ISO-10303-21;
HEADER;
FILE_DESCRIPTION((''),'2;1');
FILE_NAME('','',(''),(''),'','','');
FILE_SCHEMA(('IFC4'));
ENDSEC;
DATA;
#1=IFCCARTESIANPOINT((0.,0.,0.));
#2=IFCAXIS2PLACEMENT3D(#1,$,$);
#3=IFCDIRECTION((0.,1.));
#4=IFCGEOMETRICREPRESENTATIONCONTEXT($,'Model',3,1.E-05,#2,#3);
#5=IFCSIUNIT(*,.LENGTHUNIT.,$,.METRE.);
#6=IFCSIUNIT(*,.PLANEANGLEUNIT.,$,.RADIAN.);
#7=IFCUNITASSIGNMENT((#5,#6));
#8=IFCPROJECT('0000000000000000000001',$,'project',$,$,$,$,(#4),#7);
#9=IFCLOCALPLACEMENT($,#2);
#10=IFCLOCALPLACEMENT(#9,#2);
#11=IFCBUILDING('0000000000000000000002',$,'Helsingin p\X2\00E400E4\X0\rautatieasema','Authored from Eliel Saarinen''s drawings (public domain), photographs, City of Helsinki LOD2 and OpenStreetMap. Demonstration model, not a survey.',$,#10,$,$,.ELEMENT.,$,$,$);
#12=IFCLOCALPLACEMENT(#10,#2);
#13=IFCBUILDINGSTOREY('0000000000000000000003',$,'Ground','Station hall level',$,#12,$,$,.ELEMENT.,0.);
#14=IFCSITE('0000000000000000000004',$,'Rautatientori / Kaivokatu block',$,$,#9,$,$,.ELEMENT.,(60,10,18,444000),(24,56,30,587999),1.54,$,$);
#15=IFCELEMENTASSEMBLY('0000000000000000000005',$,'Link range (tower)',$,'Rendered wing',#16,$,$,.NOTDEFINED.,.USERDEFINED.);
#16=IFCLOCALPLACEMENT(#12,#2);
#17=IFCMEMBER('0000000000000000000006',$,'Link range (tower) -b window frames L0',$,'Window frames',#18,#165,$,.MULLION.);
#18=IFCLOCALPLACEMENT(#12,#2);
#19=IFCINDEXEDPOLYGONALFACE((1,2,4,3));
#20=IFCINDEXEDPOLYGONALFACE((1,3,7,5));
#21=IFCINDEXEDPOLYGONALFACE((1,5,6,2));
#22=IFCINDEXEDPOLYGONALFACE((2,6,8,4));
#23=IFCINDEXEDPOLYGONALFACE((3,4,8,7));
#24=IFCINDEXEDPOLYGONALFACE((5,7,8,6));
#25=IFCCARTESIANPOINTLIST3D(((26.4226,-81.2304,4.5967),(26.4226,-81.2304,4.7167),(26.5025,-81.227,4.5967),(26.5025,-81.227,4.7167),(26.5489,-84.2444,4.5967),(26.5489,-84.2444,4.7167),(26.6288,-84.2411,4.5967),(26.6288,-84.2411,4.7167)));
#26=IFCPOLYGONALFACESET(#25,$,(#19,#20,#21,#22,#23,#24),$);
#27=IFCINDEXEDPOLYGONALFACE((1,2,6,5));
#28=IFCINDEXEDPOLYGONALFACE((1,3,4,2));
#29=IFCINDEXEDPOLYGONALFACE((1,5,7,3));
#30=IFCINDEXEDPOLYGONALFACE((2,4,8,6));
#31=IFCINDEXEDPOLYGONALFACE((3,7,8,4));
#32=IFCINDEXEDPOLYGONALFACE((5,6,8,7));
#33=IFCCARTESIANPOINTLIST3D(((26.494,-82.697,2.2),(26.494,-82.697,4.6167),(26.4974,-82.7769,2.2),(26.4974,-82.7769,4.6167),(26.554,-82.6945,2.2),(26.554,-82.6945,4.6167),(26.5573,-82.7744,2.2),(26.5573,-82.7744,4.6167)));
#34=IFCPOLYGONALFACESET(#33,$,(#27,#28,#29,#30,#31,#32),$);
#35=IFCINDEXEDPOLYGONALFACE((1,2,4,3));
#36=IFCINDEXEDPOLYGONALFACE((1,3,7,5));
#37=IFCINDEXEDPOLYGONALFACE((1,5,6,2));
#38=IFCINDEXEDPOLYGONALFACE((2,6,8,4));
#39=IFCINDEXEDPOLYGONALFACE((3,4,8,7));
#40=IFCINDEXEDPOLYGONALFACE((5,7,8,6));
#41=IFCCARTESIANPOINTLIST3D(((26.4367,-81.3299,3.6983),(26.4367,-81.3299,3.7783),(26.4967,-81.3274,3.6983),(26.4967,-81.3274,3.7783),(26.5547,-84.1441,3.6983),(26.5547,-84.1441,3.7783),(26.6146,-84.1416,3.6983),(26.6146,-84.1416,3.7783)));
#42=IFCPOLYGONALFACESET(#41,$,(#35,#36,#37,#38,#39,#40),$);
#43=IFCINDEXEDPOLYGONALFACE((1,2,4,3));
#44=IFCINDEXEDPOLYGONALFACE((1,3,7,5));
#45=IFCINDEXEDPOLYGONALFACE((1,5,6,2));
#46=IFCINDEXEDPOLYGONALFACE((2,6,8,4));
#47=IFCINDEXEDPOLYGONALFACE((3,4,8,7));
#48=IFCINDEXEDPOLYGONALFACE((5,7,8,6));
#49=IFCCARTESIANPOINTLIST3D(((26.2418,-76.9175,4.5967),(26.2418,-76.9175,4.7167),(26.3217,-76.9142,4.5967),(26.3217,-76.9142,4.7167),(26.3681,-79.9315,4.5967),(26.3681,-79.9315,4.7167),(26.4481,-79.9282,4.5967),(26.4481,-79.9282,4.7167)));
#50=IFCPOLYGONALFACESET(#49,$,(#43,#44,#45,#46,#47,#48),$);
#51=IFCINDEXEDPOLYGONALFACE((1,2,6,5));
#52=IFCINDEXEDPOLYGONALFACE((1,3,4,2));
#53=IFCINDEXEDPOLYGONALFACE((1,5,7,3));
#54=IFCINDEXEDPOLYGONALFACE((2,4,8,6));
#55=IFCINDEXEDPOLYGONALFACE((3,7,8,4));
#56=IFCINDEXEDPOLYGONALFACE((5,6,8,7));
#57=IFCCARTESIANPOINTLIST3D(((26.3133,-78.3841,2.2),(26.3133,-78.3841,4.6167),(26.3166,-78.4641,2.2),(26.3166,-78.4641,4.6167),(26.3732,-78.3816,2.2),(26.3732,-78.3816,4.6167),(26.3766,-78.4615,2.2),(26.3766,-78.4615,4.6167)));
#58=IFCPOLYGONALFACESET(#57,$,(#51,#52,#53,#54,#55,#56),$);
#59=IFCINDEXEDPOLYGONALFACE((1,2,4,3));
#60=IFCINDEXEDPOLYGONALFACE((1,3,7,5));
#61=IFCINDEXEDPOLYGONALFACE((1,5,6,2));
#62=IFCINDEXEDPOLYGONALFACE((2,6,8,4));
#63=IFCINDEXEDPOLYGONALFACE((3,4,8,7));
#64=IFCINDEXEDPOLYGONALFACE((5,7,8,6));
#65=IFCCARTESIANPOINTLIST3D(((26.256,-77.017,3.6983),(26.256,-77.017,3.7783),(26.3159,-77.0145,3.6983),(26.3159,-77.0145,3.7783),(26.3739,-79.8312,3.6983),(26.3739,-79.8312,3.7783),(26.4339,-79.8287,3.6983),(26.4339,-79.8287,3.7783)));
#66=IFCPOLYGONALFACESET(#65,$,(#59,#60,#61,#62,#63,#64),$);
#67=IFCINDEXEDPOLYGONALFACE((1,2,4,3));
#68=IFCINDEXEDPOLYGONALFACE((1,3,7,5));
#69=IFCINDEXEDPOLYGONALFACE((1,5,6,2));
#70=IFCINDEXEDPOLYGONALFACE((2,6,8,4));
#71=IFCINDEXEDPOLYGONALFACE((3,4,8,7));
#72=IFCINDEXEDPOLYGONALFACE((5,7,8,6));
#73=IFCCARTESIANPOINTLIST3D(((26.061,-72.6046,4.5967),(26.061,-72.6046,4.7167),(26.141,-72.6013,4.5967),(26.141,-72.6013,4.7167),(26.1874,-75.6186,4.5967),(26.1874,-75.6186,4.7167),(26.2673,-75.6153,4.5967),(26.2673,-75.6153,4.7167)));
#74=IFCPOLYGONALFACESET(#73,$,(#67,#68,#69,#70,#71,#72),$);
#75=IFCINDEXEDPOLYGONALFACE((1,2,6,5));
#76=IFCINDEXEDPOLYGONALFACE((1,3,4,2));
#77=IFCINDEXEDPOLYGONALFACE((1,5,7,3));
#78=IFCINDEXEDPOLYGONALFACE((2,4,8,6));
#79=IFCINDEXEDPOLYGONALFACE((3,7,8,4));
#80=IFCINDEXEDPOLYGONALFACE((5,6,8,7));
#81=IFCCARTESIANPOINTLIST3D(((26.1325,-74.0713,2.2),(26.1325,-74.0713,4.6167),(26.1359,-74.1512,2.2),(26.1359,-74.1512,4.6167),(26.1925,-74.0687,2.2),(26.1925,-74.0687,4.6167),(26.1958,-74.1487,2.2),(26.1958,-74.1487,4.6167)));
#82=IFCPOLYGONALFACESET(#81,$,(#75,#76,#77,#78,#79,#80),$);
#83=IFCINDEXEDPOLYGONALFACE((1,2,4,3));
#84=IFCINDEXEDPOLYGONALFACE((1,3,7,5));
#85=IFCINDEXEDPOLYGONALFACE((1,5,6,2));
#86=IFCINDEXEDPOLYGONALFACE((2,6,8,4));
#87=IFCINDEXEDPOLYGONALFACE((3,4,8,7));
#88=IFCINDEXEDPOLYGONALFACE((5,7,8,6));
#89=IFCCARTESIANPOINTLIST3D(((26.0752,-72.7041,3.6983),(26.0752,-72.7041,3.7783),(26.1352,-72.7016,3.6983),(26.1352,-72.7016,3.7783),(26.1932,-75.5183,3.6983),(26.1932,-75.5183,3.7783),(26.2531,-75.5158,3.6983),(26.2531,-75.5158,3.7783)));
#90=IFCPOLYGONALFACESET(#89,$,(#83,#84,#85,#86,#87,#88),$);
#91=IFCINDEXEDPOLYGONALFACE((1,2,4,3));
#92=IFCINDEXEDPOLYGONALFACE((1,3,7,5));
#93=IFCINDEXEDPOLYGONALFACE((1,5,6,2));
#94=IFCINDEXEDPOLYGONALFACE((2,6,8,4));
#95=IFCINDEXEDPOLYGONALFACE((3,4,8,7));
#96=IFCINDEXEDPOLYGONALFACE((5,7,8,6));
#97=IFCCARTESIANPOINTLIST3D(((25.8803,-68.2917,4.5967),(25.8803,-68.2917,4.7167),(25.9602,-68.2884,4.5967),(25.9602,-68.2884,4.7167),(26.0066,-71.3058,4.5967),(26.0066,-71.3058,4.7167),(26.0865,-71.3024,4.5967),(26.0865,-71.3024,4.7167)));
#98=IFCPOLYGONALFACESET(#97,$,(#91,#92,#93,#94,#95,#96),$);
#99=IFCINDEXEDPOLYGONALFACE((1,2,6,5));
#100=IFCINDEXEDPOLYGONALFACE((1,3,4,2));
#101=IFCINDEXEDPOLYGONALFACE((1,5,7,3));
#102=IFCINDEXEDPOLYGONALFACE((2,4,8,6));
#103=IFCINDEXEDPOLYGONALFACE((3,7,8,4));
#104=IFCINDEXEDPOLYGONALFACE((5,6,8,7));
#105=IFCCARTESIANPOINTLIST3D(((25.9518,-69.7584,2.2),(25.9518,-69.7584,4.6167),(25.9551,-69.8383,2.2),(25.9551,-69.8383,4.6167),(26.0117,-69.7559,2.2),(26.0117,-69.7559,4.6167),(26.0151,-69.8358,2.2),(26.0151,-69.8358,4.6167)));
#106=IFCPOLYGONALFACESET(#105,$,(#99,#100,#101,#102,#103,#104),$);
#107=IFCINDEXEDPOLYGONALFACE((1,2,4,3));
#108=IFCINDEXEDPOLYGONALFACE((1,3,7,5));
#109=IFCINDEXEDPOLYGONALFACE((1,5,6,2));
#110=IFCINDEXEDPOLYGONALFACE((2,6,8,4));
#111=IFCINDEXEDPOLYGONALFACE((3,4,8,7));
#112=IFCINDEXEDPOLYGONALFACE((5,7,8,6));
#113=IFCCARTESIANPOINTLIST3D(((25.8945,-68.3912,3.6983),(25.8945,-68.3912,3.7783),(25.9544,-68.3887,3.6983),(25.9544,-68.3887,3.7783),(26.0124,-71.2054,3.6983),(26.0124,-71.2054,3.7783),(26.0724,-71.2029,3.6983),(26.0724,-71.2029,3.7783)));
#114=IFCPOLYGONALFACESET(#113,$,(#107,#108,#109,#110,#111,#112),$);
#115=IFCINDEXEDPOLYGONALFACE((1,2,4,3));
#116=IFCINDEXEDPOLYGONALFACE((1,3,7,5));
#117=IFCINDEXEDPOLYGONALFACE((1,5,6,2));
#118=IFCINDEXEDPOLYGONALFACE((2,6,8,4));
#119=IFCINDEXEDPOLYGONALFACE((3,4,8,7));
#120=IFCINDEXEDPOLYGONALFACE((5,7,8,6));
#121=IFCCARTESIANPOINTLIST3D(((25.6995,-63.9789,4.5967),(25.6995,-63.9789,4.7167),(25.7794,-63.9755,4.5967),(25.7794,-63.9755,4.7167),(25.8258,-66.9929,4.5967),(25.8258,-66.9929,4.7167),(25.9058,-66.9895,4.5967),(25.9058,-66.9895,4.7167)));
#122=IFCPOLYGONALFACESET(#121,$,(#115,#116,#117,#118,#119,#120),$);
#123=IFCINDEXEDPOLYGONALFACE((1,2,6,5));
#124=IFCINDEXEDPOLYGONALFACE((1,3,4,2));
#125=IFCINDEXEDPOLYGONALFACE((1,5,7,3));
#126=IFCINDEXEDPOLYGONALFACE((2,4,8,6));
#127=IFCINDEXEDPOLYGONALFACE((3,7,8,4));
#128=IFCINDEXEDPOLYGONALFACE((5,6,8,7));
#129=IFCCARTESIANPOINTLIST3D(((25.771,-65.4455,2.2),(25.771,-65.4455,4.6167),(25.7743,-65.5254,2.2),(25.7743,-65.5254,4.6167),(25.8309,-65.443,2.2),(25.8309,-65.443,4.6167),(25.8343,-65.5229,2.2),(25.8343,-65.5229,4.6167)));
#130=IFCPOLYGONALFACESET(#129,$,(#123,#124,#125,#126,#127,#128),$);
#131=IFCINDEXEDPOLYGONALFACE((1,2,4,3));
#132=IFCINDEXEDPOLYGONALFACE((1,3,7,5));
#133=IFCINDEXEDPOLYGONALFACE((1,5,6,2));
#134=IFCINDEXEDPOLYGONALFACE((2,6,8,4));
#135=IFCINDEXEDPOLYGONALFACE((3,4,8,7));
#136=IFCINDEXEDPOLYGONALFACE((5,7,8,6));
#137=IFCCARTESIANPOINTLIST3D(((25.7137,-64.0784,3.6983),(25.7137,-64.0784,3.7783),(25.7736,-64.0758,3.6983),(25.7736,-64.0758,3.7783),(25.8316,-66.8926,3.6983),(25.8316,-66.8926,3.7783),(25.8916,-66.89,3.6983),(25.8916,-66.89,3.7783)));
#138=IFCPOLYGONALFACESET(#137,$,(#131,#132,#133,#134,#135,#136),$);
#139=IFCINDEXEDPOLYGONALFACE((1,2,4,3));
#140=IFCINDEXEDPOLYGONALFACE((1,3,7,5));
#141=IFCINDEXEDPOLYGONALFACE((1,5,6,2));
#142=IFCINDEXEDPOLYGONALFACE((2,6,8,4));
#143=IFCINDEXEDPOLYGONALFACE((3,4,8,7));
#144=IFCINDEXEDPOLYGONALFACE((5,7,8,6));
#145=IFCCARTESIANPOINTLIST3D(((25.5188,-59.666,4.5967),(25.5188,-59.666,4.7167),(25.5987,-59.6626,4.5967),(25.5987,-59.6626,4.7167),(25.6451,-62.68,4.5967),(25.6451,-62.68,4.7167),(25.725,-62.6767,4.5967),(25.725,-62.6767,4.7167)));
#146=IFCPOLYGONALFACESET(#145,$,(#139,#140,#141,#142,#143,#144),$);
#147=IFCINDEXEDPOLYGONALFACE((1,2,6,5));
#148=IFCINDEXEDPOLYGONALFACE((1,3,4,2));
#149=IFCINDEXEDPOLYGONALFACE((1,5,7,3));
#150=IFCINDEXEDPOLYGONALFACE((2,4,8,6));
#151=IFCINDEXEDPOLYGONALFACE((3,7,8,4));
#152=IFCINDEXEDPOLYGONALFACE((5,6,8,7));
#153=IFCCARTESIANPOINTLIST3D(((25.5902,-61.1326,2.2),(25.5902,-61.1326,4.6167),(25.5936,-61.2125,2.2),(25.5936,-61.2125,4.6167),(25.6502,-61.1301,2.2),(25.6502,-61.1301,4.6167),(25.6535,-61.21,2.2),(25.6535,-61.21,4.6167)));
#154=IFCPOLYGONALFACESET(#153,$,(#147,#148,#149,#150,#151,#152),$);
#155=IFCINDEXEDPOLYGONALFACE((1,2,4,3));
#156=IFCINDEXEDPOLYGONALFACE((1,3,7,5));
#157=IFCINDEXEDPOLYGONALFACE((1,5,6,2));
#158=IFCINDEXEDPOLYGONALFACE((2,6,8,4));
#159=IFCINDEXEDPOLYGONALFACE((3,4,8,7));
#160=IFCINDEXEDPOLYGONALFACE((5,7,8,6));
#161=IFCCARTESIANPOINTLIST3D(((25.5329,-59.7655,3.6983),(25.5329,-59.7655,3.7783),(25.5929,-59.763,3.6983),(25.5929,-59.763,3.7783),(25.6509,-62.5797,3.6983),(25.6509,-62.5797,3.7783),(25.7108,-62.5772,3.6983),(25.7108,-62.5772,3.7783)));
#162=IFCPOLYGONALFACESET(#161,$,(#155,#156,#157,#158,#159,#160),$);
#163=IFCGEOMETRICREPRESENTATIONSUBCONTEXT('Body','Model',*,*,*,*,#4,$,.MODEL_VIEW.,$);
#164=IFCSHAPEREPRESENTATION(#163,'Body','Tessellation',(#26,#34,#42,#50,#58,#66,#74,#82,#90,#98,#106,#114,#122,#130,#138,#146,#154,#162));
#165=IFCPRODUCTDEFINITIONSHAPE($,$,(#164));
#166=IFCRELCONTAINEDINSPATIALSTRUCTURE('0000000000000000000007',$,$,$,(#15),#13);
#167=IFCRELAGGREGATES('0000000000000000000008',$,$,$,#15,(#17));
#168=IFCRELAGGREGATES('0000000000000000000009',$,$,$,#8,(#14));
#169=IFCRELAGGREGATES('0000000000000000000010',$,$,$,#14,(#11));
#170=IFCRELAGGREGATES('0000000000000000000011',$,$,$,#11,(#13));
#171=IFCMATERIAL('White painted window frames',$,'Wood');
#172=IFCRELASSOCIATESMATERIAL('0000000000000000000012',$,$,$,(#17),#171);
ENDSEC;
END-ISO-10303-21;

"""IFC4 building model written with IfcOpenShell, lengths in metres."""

from ifc_helpers import new_model, si_unit, direction, frame, frame_2d, origin, place, context, subcontext, project, spatial, rectangle, extrude, material, element, aggregate, save


model = new_model("IFC4")

# Units and contexts
model_context = context("Model", 3, precision=1e-05, world=origin(), true_north=direction((0.0, 1.0)))
body_context = subcontext(model_context, "Body", "Model", "MODEL_VIEW")
ifc_project = project(units=[si_unit("LENGTHUNIT", "METRE"), si_unit("PLANEANGLEUNIT", "RADIAN")], contexts=[model_context])

# Site, building, storey
site_placement = place(None, origin())
site = spatial("IfcSite", under=ifc_project, at=site_placement, Name="Rautatientori / Kaivokatu block", CompositionType="ELEMENT", RefLatitude=(60, 10, 18, 444000), RefLongitude=(24, 56, 30, 587999), RefElevation=1.54)
building_placement = place(site_placement, origin())
building = spatial("IfcBuilding", under=site, at=building_placement, Name="Helsingin päärautatieasema", Description="Authored from Eliel Saarinen's drawings (public domain), photographs, City of Helsinki LOD2 and OpenStreetMap. Demonstration model, not a survey.", CompositionType="ELEMENT")
storey_placement = place(building_placement, origin())
storey = spatial("IfcBuildingStorey", under=building, at=storey_placement, Name="Ground", Description="Station hall level", CompositionType="ELEMENT", Elevation=0.0)

# Shared definitions
ifc_material_1 = material(Name="White painted window frames", Category="Wood")

# Element assembly, member
assembly_1_placement = place(building_placement, origin())
assembly_1 = element("IfcElementAssembly", 1, at=assembly_1_placement, inside=storey, Name="Link range (tower)", ObjectType="Rendered wing", AssemblyPlace="NOTDEFINED", PredefinedType="USERDEFINED")
member_1_placement = place(building_placement, origin())
member_1 = element("IfcMember", 2, at=member_1_placement, material=ifc_material_1, Name="Link range (tower) -b window frames L0", ObjectType="Window frames", PredefinedType="MULLION", context=body_context, shape_type="SweptSolid", body=[
    extrude(rectangle(XDim=3.0167, YDim=0.08, at=frame_2d((0.0, 0.0), x_axis=(-0.041876, 0.999123))), frame((26.5257, -82.7357, 4.5967)), (0.0, 0.0, 1.0), 0.12),
    extrude(rectangle(XDim=0.08, YDim=0.06, at=frame_2d((0.0, 0.0), x_axis=(-0.041876, 0.999123))), frame((26.5257, -82.7357, 2.2)), (0.0, 0.0, 1.0), 2.4167),
    extrude(rectangle(XDim=2.8167, YDim=0.06, at=frame_2d((0.0, 0.0), x_axis=(-0.041876, 0.999123))), frame((26.5257, -82.7357, 3.6983)), (0.0, 0.0, 1.0), 0.08),
    extrude(rectangle(XDim=3.0167, YDim=0.08, at=frame_2d((0.0, 0.0), x_axis=(-0.041876, 0.999123))), frame((26.3449, -78.4228, 4.5967)), (0.0, 0.0, 1.0), 0.12),
    extrude(rectangle(XDim=0.08, YDim=0.06, at=frame_2d((0.0, 0.0), x_axis=(-0.041876, 0.999123))), frame((26.3449, -78.4228, 2.2)), (0.0, 0.0, 1.0), 2.4167),
    extrude(rectangle(XDim=2.8167, YDim=0.06, at=frame_2d((0.0, 0.0), x_axis=(-0.041876, 0.999123))), frame((26.3449, -78.4228, 3.6983)), (0.0, 0.0, 1.0), 0.08),
    extrude(rectangle(XDim=3.0167, YDim=0.08, at=frame_2d((0.0, 0.0), x_axis=(-0.041876, 0.999123))), frame((26.1642, -74.11, 4.5967)), (0.0, 0.0, 1.0), 0.12),
    extrude(rectangle(XDim=0.08, YDim=0.06, at=frame_2d((0.0, 0.0), x_axis=(-0.041876, 0.999123))), frame((26.1642, -74.11, 2.2)), (0.0, 0.0, 1.0), 2.4167),
    extrude(rectangle(XDim=2.8167, YDim=0.06, at=frame_2d((0.0, 0.0), x_axis=(-0.041876, 0.999123))), frame((26.1642, -74.11, 3.6983)), (0.0, 0.0, 1.0), 0.08),
    extrude(rectangle(XDim=3.0167, YDim=0.08, at=frame_2d((0.0, 0.0), x_axis=(-0.041876, 0.999123))), frame((25.9834, -69.7971, 4.5967)), (0.0, 0.0, 1.0), 0.12),
    extrude(rectangle(XDim=0.08, YDim=0.06, at=frame_2d((0.0, 0.0), x_axis=(-0.041876, 0.999123))), frame((25.9834, -69.7971, 2.2)), (0.0, 0.0, 1.0), 2.4167),
    extrude(rectangle(XDim=2.8167, YDim=0.06, at=frame_2d((0.0, 0.0), x_axis=(-0.041876, 0.999123))), frame((25.9834, -69.7971, 3.6983)), (0.0, 0.0, 1.0), 0.08),
    extrude(rectangle(XDim=3.0167, YDim=0.08, at=frame_2d((0.0, 0.0), x_axis=(-0.041876, 0.999123))), frame((25.8026, -65.4842, 4.5967)), (0.0, 0.0, 1.0), 0.12),
    extrude(rectangle(XDim=0.08, YDim=0.06, at=frame_2d((0.0, 0.0), x_axis=(-0.041876, 0.999123))), frame((25.8026, -65.4842, 2.2)), (0.0, 0.0, 1.0), 2.4167),
    extrude(rectangle(XDim=2.8167, YDim=0.06, at=frame_2d((0.0, 0.0), x_axis=(-0.041876, 0.999123))), frame((25.8026, -65.4842, 3.6983)), (0.0, 0.0, 1.0), 0.08),
    extrude(rectangle(XDim=3.0167, YDim=0.08, at=frame_2d((0.0, 0.0), x_axis=(-0.041876, 0.999123))), frame((25.6219, -61.1713, 4.5967)), (0.0, 0.0, 1.0), 0.12),
    extrude(rectangle(XDim=0.08, YDim=0.06, at=frame_2d((0.0, 0.0), x_axis=(-0.041876, 0.999123))), frame((25.6219, -61.1713, 2.2)), (0.0, 0.0, 1.0), 2.4167),
    extrude(rectangle(XDim=2.8167, YDim=0.06, at=frame_2d((0.0, 0.0), x_axis=(-0.041876, 0.999123))), frame((25.6219, -61.1713, 3.6983)), (0.0, 0.0, 1.0), 0.08),
])

aggregate(assembly_1, [member_1])

save(model, "model.ifc")
